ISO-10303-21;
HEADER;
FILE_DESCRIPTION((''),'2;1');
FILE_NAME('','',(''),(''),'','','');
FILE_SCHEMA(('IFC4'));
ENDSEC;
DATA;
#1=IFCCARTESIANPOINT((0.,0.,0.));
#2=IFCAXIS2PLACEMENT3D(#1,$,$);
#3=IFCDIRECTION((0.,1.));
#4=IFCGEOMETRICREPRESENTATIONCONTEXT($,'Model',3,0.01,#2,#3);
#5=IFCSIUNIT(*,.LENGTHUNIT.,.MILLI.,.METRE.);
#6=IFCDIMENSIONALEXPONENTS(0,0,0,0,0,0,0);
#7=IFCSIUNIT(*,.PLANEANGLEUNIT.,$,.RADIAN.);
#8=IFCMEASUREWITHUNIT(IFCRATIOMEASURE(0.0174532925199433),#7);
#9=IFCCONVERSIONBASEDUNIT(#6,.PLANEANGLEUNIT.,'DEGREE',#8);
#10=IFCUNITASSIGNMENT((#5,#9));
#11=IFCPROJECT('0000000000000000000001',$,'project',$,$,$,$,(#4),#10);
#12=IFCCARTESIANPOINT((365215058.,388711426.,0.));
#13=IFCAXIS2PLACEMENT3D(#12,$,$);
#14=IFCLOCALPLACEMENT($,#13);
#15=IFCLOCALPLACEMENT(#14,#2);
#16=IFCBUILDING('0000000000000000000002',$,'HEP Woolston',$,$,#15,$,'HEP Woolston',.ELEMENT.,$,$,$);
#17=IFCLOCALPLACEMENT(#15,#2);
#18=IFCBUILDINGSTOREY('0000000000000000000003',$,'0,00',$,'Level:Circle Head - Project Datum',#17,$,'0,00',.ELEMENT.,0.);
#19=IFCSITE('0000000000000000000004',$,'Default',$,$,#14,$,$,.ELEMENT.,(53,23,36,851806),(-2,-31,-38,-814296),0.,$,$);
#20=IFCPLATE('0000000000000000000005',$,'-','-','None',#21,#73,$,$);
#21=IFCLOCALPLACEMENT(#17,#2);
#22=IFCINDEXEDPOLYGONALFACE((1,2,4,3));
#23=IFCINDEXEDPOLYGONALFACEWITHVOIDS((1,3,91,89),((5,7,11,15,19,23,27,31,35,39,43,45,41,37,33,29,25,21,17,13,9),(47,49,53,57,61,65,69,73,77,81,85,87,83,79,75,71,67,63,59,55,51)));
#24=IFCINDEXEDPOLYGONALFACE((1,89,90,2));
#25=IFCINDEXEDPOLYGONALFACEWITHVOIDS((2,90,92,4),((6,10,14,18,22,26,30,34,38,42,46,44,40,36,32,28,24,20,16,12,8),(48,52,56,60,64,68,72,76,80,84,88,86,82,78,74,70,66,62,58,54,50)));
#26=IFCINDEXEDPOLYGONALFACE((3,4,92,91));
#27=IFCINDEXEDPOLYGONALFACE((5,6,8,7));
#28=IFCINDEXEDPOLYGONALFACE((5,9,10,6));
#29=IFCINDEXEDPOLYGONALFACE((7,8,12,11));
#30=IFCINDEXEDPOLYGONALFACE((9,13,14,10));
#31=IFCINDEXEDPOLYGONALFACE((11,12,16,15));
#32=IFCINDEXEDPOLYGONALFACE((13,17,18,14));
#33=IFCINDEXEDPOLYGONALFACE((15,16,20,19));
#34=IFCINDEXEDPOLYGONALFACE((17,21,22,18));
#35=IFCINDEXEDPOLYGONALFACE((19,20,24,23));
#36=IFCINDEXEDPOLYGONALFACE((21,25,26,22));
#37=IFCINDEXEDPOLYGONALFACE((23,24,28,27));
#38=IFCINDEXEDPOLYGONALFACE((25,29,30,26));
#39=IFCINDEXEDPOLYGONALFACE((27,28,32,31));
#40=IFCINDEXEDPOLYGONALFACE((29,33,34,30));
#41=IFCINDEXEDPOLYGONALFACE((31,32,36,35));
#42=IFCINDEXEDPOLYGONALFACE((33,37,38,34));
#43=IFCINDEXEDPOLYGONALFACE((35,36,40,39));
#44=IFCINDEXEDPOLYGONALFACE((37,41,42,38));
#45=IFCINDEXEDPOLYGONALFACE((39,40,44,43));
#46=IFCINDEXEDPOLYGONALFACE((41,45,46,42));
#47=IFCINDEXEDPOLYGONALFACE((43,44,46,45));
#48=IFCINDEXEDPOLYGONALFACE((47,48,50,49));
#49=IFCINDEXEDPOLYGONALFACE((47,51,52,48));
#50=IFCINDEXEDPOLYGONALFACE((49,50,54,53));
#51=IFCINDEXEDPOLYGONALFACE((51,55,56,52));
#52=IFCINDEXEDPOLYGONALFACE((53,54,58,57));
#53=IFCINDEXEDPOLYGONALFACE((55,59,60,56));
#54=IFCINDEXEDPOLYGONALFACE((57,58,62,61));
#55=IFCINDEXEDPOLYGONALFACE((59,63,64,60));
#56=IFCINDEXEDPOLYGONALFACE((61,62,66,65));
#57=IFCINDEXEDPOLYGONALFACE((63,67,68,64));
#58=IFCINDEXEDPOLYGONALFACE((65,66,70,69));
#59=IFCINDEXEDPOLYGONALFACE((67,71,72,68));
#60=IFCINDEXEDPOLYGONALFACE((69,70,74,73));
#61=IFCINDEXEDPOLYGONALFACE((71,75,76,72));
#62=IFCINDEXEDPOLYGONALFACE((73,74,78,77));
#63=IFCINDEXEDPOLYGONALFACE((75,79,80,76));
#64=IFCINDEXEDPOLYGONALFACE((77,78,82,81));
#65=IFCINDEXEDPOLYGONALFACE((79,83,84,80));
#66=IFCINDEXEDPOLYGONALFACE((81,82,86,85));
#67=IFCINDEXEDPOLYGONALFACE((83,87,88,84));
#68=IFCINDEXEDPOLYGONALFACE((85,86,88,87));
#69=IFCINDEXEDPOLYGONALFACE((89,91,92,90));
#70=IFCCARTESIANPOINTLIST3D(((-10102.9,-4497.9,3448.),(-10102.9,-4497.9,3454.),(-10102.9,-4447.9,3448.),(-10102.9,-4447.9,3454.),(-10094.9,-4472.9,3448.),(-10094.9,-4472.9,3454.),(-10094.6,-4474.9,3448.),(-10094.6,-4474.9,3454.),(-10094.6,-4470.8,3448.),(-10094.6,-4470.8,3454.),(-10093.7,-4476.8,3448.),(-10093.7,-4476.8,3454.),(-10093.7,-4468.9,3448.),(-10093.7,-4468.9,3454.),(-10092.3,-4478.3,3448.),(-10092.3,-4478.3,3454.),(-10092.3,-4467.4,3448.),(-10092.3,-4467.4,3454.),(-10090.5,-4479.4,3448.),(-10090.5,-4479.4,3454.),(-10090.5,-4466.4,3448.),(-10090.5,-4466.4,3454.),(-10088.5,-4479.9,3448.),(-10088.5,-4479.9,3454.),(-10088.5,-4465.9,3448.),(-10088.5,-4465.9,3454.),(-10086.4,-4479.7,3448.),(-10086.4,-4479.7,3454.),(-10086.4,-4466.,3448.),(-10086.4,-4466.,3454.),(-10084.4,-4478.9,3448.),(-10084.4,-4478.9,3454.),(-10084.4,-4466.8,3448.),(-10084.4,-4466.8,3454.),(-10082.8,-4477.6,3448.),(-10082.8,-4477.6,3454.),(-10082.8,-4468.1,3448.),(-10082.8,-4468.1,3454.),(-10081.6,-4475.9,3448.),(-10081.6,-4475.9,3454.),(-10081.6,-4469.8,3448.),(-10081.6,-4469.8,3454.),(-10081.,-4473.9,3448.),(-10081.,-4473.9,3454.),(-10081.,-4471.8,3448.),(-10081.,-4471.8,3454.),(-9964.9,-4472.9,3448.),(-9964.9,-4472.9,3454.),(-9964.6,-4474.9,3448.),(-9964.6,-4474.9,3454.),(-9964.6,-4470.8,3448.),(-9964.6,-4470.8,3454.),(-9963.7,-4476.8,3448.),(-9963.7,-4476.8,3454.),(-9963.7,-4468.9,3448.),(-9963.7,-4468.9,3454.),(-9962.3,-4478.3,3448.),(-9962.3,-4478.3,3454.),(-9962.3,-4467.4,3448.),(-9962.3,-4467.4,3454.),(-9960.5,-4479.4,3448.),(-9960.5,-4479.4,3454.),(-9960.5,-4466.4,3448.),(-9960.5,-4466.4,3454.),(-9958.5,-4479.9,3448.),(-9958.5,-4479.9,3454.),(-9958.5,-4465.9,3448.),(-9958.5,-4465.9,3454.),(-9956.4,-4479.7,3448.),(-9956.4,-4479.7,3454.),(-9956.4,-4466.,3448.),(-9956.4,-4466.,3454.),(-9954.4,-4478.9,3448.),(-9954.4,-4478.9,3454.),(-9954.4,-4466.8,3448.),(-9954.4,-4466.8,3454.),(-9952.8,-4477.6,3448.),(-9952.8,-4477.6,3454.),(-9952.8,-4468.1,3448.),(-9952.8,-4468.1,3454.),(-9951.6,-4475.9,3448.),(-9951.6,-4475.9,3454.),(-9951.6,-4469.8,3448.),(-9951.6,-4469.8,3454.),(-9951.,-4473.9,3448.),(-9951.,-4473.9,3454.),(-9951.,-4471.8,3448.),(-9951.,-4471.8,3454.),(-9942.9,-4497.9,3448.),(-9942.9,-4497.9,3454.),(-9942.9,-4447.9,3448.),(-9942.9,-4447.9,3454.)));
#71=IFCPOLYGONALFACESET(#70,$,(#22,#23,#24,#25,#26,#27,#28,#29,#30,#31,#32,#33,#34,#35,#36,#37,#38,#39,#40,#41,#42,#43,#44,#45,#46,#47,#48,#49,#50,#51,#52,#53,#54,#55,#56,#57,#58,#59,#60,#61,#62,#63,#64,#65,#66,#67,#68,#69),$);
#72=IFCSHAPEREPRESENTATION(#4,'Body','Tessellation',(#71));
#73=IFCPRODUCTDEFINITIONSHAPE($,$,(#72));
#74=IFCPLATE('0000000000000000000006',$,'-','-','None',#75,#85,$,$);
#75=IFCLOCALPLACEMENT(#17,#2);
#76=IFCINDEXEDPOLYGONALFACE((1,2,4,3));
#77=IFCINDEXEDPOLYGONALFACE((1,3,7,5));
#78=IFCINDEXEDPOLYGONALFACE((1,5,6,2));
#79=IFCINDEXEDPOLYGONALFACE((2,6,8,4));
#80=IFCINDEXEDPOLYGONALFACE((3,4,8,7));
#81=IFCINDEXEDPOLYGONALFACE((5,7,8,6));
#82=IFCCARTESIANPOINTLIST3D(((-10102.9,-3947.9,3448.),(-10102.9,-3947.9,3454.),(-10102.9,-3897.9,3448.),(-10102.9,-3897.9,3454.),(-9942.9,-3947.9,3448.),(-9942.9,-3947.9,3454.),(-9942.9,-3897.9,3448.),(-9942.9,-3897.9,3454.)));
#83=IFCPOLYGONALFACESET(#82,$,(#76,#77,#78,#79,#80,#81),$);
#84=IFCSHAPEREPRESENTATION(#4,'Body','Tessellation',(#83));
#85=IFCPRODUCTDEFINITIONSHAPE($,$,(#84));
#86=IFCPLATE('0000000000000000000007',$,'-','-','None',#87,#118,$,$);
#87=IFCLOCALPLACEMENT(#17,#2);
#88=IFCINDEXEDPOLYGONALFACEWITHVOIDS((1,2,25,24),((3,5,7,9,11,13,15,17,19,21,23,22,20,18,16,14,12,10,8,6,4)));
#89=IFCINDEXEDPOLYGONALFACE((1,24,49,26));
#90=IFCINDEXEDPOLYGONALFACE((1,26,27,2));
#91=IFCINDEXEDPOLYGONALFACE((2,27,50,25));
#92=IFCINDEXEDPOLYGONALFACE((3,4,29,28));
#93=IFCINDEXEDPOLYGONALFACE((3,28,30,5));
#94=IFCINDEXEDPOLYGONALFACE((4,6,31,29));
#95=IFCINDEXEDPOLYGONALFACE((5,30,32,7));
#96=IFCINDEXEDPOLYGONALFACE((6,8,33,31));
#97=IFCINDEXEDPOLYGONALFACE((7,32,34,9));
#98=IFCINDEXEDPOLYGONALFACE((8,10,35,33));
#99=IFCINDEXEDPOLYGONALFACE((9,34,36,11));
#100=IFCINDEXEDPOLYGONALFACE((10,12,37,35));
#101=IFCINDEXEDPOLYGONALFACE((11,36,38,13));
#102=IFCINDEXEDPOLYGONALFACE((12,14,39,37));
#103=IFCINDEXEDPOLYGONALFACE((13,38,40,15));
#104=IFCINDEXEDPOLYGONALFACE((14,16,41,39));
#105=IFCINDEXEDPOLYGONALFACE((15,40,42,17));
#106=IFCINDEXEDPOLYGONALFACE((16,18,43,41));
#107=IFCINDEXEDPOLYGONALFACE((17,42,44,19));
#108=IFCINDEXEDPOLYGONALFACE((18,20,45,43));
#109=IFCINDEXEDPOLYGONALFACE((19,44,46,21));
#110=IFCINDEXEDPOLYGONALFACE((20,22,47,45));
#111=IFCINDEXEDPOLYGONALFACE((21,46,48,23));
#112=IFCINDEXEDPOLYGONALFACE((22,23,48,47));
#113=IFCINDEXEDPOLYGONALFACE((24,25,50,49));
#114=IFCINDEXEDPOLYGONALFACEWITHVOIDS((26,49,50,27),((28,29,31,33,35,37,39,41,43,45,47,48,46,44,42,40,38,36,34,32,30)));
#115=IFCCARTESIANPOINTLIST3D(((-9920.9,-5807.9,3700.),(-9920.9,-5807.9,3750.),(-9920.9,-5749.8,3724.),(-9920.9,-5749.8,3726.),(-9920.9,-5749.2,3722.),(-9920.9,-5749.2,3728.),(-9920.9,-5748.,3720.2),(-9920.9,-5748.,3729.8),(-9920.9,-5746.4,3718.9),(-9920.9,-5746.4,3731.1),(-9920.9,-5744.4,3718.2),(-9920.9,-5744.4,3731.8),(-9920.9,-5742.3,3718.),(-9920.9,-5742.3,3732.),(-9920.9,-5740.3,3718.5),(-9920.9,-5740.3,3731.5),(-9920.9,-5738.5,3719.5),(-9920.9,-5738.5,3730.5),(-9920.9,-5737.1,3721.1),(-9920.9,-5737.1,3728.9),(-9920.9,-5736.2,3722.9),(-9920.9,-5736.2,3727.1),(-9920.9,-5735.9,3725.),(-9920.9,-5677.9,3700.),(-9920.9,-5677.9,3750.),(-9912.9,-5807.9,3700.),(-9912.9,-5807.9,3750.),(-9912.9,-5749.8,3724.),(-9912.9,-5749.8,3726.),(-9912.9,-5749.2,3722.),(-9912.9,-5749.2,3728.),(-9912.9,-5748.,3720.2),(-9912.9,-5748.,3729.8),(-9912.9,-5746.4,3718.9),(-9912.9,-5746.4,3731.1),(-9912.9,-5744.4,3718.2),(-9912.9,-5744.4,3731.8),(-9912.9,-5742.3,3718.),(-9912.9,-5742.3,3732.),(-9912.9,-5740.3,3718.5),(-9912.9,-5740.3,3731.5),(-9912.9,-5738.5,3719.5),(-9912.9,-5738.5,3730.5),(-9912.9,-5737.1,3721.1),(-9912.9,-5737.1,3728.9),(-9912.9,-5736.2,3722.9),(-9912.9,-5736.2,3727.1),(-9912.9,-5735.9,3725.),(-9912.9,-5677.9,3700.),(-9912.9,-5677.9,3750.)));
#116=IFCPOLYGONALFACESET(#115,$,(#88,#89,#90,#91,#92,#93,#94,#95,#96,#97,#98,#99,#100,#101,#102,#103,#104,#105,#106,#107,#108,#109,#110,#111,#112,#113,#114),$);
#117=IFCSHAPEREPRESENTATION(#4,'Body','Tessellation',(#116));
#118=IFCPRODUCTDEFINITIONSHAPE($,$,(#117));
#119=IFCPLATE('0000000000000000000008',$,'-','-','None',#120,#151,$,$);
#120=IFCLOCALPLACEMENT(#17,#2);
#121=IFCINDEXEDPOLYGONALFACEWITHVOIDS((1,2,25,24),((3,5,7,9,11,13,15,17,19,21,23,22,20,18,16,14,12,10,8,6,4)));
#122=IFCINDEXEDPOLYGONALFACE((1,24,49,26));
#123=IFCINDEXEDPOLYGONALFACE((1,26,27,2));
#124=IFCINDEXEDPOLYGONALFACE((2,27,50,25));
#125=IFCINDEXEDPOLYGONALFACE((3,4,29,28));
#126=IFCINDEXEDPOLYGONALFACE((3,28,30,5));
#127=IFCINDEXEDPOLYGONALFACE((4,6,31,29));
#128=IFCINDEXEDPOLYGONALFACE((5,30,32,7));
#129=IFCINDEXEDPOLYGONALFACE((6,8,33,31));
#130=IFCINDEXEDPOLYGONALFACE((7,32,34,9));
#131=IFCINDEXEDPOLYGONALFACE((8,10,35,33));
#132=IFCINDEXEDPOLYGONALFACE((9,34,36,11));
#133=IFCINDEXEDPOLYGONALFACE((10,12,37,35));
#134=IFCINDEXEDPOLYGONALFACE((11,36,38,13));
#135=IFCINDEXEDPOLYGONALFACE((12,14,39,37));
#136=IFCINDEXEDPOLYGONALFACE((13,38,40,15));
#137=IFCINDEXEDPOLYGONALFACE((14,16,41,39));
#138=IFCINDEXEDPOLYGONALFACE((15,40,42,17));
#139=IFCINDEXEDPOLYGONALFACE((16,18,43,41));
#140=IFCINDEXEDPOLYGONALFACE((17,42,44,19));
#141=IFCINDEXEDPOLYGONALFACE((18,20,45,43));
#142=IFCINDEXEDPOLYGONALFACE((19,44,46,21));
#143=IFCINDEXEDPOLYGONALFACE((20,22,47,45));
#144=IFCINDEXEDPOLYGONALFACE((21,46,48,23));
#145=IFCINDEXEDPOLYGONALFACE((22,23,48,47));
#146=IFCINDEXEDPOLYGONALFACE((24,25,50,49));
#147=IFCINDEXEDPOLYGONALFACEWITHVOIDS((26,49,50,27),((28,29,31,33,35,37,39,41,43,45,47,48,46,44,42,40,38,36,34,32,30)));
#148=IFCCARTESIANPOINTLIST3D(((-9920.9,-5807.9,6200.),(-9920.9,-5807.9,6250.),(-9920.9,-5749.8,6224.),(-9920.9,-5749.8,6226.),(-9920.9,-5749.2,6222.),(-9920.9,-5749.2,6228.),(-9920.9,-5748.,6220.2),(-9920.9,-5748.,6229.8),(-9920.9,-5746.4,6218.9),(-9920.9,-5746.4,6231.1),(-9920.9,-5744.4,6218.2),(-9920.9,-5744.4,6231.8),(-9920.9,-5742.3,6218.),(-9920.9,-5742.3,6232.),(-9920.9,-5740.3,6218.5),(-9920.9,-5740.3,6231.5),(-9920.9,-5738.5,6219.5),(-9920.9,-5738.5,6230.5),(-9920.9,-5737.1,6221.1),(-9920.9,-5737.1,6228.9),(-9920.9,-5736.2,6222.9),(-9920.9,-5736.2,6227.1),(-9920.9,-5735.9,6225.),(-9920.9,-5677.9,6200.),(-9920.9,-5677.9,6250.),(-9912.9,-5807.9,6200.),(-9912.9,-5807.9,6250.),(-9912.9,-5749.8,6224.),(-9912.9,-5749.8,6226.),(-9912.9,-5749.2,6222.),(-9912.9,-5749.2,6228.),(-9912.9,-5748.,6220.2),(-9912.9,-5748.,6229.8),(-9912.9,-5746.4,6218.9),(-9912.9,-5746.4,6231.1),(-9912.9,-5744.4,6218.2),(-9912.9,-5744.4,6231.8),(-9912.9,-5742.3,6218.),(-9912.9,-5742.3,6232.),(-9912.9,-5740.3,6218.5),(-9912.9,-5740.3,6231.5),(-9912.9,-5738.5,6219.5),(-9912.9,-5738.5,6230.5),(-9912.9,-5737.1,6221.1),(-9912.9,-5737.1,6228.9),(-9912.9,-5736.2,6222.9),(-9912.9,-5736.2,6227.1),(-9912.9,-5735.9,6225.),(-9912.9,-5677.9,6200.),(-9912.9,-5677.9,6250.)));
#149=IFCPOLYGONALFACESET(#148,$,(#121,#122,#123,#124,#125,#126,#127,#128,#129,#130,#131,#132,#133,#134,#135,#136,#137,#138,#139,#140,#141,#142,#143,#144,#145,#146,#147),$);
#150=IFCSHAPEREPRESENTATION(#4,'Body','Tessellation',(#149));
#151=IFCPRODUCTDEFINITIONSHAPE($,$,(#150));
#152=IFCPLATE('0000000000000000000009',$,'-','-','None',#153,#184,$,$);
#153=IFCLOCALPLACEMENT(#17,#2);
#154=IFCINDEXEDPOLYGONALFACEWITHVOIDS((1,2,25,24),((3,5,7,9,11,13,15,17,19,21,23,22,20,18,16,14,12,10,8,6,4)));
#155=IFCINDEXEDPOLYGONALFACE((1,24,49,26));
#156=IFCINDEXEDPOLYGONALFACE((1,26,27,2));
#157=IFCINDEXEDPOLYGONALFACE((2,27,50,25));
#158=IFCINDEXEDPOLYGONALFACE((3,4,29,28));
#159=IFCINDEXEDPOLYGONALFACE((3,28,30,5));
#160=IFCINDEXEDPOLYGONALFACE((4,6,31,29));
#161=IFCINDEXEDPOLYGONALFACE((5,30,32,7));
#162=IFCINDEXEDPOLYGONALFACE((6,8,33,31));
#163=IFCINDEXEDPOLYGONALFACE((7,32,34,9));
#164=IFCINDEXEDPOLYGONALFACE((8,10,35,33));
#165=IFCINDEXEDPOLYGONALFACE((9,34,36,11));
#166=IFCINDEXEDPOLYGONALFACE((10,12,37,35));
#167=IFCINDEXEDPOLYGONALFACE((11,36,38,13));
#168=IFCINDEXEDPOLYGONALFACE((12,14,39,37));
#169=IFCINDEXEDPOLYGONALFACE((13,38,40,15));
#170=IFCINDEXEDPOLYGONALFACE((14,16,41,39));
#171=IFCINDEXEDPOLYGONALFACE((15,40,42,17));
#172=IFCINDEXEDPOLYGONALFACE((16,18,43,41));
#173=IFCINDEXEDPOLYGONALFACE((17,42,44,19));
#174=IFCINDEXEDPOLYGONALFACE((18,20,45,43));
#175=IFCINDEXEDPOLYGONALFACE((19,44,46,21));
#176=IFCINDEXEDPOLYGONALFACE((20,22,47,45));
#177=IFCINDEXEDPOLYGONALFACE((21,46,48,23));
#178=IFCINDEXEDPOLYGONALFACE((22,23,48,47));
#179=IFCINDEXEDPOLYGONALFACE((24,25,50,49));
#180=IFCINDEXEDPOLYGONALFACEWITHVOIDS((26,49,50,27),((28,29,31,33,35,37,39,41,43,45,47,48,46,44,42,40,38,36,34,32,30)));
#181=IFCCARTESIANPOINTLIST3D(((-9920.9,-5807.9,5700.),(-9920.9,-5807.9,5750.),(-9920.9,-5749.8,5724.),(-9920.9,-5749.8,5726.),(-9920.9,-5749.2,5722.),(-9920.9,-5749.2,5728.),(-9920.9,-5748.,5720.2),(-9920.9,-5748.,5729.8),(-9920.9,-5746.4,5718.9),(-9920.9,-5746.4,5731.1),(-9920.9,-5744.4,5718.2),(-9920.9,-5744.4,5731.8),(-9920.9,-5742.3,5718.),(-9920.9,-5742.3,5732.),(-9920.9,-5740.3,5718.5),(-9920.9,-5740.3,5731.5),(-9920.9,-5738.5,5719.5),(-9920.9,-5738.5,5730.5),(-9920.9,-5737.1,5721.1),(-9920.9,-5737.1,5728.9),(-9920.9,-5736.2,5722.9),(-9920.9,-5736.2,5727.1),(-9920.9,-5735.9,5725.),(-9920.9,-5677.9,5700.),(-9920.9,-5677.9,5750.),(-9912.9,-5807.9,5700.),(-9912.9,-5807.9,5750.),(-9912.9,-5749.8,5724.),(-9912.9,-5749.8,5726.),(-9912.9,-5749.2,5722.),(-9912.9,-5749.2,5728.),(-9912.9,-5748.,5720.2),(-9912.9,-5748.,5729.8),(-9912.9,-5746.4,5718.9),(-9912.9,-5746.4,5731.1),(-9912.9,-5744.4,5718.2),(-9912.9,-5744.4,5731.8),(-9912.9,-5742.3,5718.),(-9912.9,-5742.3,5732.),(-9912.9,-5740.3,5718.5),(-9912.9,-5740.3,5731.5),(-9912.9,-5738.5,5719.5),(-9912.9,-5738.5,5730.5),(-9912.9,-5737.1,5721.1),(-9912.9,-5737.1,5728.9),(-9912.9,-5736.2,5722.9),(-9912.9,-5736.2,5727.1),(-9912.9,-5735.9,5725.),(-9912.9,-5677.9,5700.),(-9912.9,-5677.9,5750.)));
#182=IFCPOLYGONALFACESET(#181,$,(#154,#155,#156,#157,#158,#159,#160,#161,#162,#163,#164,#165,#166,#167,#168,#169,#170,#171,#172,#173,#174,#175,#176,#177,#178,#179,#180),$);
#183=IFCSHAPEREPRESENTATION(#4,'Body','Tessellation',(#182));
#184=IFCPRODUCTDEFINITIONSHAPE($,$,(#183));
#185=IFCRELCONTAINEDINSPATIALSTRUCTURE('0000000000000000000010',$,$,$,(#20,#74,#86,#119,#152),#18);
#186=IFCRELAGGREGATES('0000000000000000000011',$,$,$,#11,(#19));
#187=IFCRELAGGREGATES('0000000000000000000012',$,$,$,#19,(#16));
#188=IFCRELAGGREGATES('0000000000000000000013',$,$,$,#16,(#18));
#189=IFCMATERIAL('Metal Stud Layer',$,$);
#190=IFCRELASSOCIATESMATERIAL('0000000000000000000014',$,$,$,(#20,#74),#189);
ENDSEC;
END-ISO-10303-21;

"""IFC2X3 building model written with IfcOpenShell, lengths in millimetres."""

from ifc_helpers import new_model, entity, si_unit, converted_unit, direction, frame, frame_2d, origin, origin_with_axes, origin_2d_with_axis, place, context, project, spatial, polyline, circle, outline, extrude, material, element, save


model = new_model("IFC2X3")

# Units and contexts
model_context = context("Model", 3, precision=0.01, world=origin(), true_north=direction((0.0, 1.0)))
ifc_project = project(units=[si_unit("LENGTHUNIT", "METRE", prefix="MILLI"), converted_unit("PLANEANGLEUNIT", "DEGREE", entity("IfcRatioMeasure", 0.0174532925199433), si_unit("PLANEANGLEUNIT", "RADIAN"), dimensions=[0, 0, 0, 0, 0, 0, 0])], contexts=[model_context])

# Site, building, storey
site_placement = place(None, frame((365215058.0, 388711426.0, 0.0)))
site = spatial("IfcSite", under=ifc_project, at=site_placement, Name="Default", CompositionType="ELEMENT", RefLatitude=(53, 23, 36, 851806), RefLongitude=(-2, -31, -38, -814296), RefElevation=0.0)
building_placement = place(site_placement, origin())
building = spatial("IfcBuilding", under=site, at=building_placement, Name="HEP Woolston", LongName="HEP Woolston", CompositionType="ELEMENT")
storey_placement = place(building_placement, origin())
storey = spatial("IfcBuildingStorey", under=building, at=storey_placement, Name="0,00", ObjectType="Level:Circle Head - Project Datum", LongName="0,00", CompositionType="ELEMENT", Elevation=0.0)

# Plate, openings
ifc_material = material(Name="Metal Stud Layer")
plate_1_placement = place(storey_placement, frame((-9942.9, -4497.9, 3454.0), z_axis=(0.0, 0.0, -1.0), x_axis=(-1.0, 0.0, 0.0)))
plate_1 = element("IfcPlate", 1, at=plate_1_placement, inside=storey, material=ifc_material, Name="-", Description="-", ObjectType="None", context=model_context, shape_type="SweptSolid", body=[
    extrude(outline(polyline([(160.0, 0.0), (160.0, 50.0), (0.0, 50.0), (0.0, 0.0), (160.0, 0.0)])), origin_with_axes(), (0.0, 0.0, 1.0), 6.0),
])
opening_1_placement = place(plate_1_placement, frame((80.0, 25.0, 6.5), z_axis=(0.0, 0.0, -1.0), x_axis=(1.0, 0.0, 0.0)))
element("IfcOpeningElement", 2, at=opening_1_placement, cuts=plate_1, ObjectType="Opening", context=model_context, shape_type="SweptSolid", body=[
    extrude(circle(Radius=7.0, at=frame_2d((65.0, 0.0), x_axis=(1.0, 0.0))), origin(), (0.0, 0.0, 1.0), 7.0),
])
opening_2_placement = place(plate_1_placement, frame((80.0, 25.0, 6.5), z_axis=(0.0, 0.0, -1.0), x_axis=(1.0, 0.0, 0.0)))
element("IfcOpeningElement", 3, at=opening_2_placement, cuts=plate_1, ObjectType="Opening", context=model_context, shape_type="SweptSolid", body=[
    extrude(circle(Radius=7.0, at=frame_2d((-65.0, 0.0), x_axis=(1.0, 0.0))), origin(), (0.0, 0.0, 1.0), 7.0),
])

# Plate
plate_2_placement = place(storey_placement, frame((-9942.9, -3947.9, 3454.0), z_axis=(0.0, 0.0, -1.0), x_axis=(-1.0, 0.0, 0.0)))
element("IfcPlate", 4, at=plate_2_placement, inside=storey, material=ifc_material, Name="-", Description="-", ObjectType="None", context=model_context, shape_type="SweptSolid", body=[
    extrude(outline(polyline([(160.0, 0.0), (160.0, 50.0), (0.0, 50.0), (0.0, 0.0), (160.0, 0.0)])), origin_with_axes(), (0.0, 0.0, 1.0), 6.0),
])

# Plates, openings
plate_3_placement = place(storey_placement, frame((-9920.9, -5807.9, 3750.0), z_axis=(1.0, 0.0, 0.0), x_axis=(0.0, 1.0, 0.0)))
plate_3 = element("IfcPlate", 5, at=plate_3_placement, inside=storey, Name="-", Description="-", ObjectType="None", context=model_context, shape_type="SweptSolid", body=[
    extrude(outline(polyline([(0.0, -50.0), (130.0, -50.0), (130.0, 0.0), (0.0, 0.0), (0.0, -50.0)])), origin_with_axes(), (0.0, 0.0, 1.0), 8.0),
])
opening_3_placement = place(plate_3_placement, frame((65.0, -25.0, 8.5), z_axis=(0.0, 0.0, -1.0), x_axis=(1.0, 0.0, 0.0)))
element("IfcOpeningElement", 6, at=opening_3_placement, cuts=plate_3, ObjectType="Opening", context=model_context, shape_type="SweptSolid", body=[
    extrude(circle(Radius=7.0, at=origin_2d_with_axis()), origin(), (0.0, 0.0, 1.0), 9.0),
])
plate_4_placement = place(storey_placement, frame((-9920.9, -5807.9, 6250.0), z_axis=(1.0, 0.0, 0.0), x_axis=(0.0, 1.0, 0.0)))
plate_4 = element("IfcPlate", 7, at=plate_4_placement, inside=storey, Name="-", Description="-", ObjectType="None", context=model_context, shape_type="SweptSolid", body=[
    extrude(outline(polyline([(0.0, -50.0), (130.0, -50.0), (130.0, 0.0), (0.0, 0.0), (0.0, -50.0)])), origin_with_axes(), (0.0, 0.0, 1.0), 8.0),
])
opening_4_placement = place(plate_4_placement, frame((65.0, -25.0, 8.5), z_axis=(0.0, 0.0, -1.0), x_axis=(1.0, 0.0, 0.0)))
element("IfcOpeningElement", 8, at=opening_4_placement, cuts=plate_4, ObjectType="Opening", context=model_context, shape_type="SweptSolid", body=[
    extrude(circle(Radius=7.0, at=origin_2d_with_axis()), origin(), (0.0, 0.0, 1.0), 9.0),
])
plate_5_placement = place(storey_placement, frame((-9920.9, -5807.9, 5750.0), z_axis=(1.0, 0.0, 0.0), x_axis=(0.0, 1.0, 0.0)))
plate_5 = element("IfcPlate", 9, at=plate_5_placement, inside=storey, Name="-", Description="-", ObjectType="None", context=model_context, shape_type="SweptSolid", body=[
    extrude(outline(polyline([(0.0, -50.0), (130.0, -50.0), (130.0, 0.0), (0.0, 0.0), (0.0, -50.0)])), origin_with_axes(), (0.0, 0.0, 1.0), 8.0),
])
opening_5_placement = place(plate_5_placement, frame((65.0, -25.0, 8.5), z_axis=(0.0, 0.0, -1.0), x_axis=(1.0, 0.0, 0.0)))
element("IfcOpeningElement", 10, at=opening_5_placement, cuts=plate_5, ObjectType="Opening", context=model_context, shape_type="SweptSolid", body=[
    extrude(circle(Radius=7.0, at=origin_2d_with_axis()), origin(), (0.0, 0.0, 1.0), 9.0),
])

save(model, "model.ifc")
